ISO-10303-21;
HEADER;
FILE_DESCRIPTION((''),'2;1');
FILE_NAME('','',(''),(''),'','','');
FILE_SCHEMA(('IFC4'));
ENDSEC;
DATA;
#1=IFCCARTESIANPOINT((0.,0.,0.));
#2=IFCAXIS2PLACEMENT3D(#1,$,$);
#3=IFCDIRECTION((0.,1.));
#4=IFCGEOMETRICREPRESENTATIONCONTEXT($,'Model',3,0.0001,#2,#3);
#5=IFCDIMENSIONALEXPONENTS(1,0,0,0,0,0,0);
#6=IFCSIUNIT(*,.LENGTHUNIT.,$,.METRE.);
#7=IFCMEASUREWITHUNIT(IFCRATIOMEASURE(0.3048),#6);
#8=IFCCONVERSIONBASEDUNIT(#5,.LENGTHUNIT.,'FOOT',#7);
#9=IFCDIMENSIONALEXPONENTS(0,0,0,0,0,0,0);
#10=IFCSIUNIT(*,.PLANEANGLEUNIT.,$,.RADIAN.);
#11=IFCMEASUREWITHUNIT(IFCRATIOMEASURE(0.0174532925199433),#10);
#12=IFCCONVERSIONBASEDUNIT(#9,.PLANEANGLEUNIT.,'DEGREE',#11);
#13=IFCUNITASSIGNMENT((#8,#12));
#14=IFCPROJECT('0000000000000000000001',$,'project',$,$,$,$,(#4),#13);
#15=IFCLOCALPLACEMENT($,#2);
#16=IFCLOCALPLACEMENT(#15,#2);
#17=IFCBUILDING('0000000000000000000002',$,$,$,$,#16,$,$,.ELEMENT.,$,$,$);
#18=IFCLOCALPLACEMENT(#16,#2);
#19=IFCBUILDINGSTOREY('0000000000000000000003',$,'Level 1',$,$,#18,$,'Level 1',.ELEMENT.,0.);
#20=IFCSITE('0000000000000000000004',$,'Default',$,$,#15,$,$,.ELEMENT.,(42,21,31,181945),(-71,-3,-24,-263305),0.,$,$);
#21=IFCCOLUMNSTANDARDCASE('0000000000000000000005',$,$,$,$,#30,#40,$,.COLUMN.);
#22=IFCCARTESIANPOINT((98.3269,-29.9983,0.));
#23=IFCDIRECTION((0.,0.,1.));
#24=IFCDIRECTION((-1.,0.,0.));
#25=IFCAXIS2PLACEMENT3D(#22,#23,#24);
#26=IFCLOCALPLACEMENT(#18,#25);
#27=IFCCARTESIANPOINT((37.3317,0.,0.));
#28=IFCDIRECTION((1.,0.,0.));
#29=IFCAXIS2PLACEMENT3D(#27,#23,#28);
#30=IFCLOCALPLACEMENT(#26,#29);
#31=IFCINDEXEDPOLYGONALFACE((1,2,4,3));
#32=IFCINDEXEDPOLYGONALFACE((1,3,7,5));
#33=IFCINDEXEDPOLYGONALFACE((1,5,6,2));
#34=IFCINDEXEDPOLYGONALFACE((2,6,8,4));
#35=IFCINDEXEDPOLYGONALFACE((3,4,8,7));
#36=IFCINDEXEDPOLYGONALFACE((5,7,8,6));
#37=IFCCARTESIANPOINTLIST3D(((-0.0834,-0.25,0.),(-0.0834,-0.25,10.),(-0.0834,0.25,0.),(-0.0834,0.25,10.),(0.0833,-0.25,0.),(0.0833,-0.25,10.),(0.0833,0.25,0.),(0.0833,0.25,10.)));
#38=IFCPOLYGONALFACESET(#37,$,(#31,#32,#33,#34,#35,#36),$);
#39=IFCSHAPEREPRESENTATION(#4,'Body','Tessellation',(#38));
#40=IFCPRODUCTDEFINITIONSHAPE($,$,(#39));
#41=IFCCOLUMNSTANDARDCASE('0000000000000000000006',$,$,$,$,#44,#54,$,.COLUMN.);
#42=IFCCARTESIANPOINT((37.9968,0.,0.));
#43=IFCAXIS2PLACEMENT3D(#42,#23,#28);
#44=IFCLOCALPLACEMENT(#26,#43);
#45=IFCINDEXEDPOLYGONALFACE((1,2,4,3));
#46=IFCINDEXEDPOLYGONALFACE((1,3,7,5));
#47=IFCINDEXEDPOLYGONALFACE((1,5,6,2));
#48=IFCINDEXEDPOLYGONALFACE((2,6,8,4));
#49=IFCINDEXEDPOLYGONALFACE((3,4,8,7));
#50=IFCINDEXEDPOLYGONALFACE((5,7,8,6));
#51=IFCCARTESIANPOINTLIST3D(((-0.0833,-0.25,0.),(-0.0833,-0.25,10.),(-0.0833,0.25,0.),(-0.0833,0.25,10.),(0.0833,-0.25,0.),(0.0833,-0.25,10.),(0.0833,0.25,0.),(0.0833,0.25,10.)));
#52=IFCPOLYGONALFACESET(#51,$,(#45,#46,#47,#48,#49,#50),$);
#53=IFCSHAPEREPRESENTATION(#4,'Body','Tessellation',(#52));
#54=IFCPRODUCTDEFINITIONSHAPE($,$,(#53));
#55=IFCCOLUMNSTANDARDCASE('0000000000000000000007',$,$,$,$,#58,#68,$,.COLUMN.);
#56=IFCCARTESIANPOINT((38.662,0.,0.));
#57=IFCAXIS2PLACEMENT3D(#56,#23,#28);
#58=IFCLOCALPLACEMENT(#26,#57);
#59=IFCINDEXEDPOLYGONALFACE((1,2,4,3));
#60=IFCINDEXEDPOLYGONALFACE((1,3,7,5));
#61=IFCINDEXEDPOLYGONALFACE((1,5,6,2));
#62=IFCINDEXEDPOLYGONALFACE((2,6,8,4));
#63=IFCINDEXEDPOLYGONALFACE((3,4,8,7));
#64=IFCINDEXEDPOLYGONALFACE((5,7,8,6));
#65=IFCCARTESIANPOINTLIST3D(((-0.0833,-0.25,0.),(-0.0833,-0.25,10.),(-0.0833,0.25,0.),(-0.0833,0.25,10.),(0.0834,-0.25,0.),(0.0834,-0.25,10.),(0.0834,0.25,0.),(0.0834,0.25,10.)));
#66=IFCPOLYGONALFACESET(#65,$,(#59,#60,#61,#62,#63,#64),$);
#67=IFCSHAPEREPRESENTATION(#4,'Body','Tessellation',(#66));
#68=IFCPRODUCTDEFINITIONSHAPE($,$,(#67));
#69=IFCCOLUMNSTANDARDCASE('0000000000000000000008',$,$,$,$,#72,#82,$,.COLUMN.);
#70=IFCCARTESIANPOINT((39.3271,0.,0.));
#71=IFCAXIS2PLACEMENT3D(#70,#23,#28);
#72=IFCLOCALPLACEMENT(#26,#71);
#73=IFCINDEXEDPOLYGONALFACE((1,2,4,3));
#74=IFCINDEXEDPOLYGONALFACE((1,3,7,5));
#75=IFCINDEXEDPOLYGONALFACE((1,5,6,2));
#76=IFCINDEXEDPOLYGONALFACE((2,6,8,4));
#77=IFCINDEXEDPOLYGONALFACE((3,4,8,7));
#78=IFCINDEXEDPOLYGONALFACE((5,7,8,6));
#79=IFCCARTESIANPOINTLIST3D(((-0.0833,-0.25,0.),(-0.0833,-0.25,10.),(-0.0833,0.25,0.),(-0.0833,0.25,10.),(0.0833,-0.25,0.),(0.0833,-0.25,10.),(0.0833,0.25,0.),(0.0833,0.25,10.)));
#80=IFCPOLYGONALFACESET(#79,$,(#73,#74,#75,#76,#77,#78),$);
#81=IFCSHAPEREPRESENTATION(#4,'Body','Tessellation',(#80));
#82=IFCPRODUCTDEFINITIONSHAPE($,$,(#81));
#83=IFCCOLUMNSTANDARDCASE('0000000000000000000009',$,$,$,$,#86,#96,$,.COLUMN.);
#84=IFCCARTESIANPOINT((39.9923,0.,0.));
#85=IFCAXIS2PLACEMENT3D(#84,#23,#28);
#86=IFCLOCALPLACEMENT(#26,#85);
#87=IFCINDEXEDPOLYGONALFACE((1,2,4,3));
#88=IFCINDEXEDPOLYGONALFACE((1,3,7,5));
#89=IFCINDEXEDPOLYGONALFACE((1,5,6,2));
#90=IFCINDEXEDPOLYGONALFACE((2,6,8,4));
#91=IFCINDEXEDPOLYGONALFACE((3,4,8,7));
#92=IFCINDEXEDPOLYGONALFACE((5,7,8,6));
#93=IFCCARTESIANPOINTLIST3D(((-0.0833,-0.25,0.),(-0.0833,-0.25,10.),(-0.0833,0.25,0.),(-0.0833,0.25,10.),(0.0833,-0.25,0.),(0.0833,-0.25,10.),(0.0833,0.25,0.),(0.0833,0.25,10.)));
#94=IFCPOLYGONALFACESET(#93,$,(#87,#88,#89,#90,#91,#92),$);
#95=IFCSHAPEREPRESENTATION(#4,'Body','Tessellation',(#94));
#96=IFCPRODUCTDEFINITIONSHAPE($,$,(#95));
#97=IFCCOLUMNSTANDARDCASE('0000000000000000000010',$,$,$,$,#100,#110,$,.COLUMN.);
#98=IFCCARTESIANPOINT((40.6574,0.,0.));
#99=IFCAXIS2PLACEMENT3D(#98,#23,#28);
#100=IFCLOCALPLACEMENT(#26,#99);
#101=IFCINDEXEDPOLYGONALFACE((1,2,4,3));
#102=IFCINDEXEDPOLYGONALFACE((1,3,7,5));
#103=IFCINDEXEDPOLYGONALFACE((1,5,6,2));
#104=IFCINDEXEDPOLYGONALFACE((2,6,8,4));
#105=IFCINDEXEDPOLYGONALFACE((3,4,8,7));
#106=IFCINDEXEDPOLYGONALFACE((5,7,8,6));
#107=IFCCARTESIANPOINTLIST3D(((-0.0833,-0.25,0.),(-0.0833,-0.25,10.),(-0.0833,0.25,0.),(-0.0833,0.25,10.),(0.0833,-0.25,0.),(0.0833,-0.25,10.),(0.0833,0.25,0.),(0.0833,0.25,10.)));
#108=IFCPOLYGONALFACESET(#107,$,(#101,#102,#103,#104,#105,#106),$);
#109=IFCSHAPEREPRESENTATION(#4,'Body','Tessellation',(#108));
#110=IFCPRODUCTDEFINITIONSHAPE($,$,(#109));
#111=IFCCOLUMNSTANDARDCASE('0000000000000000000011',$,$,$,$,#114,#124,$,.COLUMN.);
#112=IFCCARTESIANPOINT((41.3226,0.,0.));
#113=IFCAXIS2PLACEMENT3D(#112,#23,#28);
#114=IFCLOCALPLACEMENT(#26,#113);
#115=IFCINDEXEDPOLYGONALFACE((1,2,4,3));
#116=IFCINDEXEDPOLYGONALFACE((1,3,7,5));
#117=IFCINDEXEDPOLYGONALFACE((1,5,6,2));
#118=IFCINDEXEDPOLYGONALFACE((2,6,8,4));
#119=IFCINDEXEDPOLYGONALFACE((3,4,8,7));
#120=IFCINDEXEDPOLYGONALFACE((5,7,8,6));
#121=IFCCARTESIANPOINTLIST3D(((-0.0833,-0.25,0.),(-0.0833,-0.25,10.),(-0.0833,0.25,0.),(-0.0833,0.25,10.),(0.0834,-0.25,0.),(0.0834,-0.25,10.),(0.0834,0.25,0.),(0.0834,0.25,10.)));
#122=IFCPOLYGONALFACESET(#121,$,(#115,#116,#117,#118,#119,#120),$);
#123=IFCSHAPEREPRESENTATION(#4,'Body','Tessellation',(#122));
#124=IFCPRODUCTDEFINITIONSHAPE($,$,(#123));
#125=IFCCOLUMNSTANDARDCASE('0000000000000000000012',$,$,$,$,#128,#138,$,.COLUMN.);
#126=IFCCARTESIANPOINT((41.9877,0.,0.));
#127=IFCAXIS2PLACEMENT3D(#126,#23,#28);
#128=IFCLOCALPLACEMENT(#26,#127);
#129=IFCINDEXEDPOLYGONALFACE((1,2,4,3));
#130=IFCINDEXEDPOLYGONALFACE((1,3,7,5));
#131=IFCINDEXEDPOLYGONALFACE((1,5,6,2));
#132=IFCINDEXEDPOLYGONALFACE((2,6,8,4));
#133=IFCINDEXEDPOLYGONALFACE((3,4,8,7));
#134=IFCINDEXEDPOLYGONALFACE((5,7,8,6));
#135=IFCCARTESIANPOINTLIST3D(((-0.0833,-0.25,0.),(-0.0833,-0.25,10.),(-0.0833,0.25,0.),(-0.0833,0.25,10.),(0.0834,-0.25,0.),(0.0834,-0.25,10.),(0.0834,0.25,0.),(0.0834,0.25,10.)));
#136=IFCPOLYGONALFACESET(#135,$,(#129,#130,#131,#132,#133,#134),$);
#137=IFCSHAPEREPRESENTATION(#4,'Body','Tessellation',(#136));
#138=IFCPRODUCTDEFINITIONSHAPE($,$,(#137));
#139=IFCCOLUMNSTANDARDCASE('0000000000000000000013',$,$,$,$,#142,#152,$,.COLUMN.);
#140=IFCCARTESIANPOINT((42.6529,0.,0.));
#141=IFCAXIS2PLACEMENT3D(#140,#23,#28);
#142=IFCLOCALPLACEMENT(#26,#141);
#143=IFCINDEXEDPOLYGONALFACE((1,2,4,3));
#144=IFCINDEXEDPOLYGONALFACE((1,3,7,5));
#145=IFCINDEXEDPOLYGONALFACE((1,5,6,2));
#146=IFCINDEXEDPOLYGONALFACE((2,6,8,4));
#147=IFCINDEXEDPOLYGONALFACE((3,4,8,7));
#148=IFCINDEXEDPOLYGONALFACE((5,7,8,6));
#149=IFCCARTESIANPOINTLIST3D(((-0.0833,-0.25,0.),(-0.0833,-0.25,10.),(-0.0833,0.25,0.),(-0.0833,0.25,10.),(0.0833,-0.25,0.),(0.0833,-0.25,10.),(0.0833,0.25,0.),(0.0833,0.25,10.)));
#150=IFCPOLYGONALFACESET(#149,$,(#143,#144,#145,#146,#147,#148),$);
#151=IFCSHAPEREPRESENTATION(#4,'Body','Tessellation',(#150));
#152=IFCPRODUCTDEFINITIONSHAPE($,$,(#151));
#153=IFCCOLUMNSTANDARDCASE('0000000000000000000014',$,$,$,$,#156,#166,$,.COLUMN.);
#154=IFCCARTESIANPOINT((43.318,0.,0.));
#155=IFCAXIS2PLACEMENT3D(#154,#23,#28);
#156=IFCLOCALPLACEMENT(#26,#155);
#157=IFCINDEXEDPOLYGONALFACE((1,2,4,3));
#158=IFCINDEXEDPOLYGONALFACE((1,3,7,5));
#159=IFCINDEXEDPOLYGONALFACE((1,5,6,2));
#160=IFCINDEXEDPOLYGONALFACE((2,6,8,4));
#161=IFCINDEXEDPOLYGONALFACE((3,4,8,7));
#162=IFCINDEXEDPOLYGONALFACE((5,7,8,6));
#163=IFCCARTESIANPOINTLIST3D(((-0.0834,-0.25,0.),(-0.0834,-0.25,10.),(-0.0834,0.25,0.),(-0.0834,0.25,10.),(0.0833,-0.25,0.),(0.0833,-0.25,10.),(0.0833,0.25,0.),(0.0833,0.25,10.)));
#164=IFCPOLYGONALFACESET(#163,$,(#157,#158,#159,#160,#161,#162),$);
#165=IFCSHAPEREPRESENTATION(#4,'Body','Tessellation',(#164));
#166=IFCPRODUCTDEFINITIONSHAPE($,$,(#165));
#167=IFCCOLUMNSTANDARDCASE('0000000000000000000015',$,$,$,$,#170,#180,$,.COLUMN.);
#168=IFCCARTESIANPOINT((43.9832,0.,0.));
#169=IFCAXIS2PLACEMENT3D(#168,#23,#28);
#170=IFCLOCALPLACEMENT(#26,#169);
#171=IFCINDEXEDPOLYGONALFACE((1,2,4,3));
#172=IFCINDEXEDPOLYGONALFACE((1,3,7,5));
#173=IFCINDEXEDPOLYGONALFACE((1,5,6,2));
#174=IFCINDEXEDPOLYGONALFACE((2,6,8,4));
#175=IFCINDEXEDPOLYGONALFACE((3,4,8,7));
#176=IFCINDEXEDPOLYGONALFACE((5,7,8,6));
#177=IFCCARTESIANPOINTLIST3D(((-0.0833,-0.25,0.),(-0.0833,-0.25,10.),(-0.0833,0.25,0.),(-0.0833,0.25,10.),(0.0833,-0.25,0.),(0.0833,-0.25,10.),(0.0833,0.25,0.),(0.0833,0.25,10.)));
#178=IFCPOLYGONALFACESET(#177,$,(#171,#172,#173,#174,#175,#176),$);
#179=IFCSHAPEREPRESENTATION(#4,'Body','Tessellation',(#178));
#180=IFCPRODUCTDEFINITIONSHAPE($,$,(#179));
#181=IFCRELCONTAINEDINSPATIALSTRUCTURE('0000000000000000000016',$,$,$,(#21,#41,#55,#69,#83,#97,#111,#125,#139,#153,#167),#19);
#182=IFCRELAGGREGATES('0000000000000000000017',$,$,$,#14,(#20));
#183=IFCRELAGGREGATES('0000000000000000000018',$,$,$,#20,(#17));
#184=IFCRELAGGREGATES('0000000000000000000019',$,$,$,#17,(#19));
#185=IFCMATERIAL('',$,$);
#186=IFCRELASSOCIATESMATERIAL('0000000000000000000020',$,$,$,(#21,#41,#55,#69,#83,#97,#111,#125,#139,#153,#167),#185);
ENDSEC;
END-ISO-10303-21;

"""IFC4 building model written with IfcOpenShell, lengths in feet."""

from ifc_helpers import new_model, entity, si_unit, converted_unit, direction, frame, origin, place, context, project, spatial, rectangle, extrude, material, element, save


model = new_model("IFC4")

# Units and contexts
model_context = context("Model", 3, precision=0.0001, world=origin(), true_north=direction((0.0, 1.0)))
ifc_project = project(units=[converted_unit("LENGTHUNIT", "FOOT", entity("IfcRatioMeasure", 0.3048), si_unit("LENGTHUNIT", "METRE"), dimensions=[1, 0, 0, 0, 0, 0, 0]), converted_unit("PLANEANGLEUNIT", "DEGREE", entity("IfcRatioMeasure", 0.0174532925199433), si_unit("PLANEANGLEUNIT", "RADIAN"), dimensions=[0, 0, 0, 0, 0, 0, 0])], contexts=[model_context])

# Site, building, storey
site_placement = place(None, origin())
site = spatial("IfcSite", under=ifc_project, at=site_placement, Name="Default", CompositionType="ELEMENT", RefLatitude=(42, 21, 31, 181945), RefLongitude=(-71, -3, -24, -263305), RefElevation=0.0)
building_placement = place(site_placement, origin())
building = spatial("IfcBuilding", under=site, at=building_placement, CompositionType="ELEMENT")
storey_placement = place(building_placement, origin())
storey = spatial("IfcBuildingStorey", under=building, at=storey_placement, Name="Level 1", LongName="Level 1", CompositionType="ELEMENT", Elevation=0.0)

# Columns
ifc_material = material(Name="")
placement = place(storey_placement, frame((98.3269, -29.9983, 0.0), z_axis=(0.0, 0.0, 1.0), x_axis=(-1.0, 0.0, 0.0)))
for number, where, z_axis, x_axis in (
    (1, (37.3317, 0.0, 0.0), (0.0, 0.0, 1.0), (1.0, 0.0, 0.0)),
    (2, (37.9968, 0.0, 0.0), (0.0, 0.0, 1.0), (1.0, 0.0, 0.0)),
    (3, (38.662, 0.0, 0.0), (0.0, 0.0, 1.0), (1.0, 0.0, 0.0)),
    (4, (39.3271, 0.0, 0.0), (0.0, 0.0, 1.0), (1.0, 0.0, 0.0)),
    (5, (39.9923, 0.0, 0.0), (0.0, 0.0, 1.0), (1.0, 0.0, 0.0)),
    (6, (40.6574, 0.0, 0.0), (0.0, 0.0, 1.0), (1.0, 0.0, 0.0)),
    (7, (41.3226, 0.0, 0.0), (0.0, 0.0, 1.0), (1.0, 0.0, 0.0)),
    (8, (41.9877, 0.0, 0.0), (0.0, 0.0, 1.0), (1.0, 0.0, 0.0)),
    (9, (42.6529, 0.0, 0.0), (0.0, 0.0, 1.0), (1.0, 0.0, 0.0)),
    (10, (43.318, 0.0, 0.0), (0.0, 0.0, 1.0), (1.0, 0.0, 0.0)),
    (11, (43.9832, 0.0, 0.0), (0.0, 0.0, 1.0), (1.0, 0.0, 0.0)),
):
    element("IfcColumnStandardCase", number, at=place(placement, frame(where, z_axis=z_axis, x_axis=x_axis)), inside=storey, material=ifc_material, PredefinedType="COLUMN", context=model_context, shape_type="SweptSolid", body=[
        extrude(rectangle(XDim=0.1667, YDim=0.5), origin(), (0.0, 0.0, 1.0), 10.0),
    ])

save(model, "model.ifc")
